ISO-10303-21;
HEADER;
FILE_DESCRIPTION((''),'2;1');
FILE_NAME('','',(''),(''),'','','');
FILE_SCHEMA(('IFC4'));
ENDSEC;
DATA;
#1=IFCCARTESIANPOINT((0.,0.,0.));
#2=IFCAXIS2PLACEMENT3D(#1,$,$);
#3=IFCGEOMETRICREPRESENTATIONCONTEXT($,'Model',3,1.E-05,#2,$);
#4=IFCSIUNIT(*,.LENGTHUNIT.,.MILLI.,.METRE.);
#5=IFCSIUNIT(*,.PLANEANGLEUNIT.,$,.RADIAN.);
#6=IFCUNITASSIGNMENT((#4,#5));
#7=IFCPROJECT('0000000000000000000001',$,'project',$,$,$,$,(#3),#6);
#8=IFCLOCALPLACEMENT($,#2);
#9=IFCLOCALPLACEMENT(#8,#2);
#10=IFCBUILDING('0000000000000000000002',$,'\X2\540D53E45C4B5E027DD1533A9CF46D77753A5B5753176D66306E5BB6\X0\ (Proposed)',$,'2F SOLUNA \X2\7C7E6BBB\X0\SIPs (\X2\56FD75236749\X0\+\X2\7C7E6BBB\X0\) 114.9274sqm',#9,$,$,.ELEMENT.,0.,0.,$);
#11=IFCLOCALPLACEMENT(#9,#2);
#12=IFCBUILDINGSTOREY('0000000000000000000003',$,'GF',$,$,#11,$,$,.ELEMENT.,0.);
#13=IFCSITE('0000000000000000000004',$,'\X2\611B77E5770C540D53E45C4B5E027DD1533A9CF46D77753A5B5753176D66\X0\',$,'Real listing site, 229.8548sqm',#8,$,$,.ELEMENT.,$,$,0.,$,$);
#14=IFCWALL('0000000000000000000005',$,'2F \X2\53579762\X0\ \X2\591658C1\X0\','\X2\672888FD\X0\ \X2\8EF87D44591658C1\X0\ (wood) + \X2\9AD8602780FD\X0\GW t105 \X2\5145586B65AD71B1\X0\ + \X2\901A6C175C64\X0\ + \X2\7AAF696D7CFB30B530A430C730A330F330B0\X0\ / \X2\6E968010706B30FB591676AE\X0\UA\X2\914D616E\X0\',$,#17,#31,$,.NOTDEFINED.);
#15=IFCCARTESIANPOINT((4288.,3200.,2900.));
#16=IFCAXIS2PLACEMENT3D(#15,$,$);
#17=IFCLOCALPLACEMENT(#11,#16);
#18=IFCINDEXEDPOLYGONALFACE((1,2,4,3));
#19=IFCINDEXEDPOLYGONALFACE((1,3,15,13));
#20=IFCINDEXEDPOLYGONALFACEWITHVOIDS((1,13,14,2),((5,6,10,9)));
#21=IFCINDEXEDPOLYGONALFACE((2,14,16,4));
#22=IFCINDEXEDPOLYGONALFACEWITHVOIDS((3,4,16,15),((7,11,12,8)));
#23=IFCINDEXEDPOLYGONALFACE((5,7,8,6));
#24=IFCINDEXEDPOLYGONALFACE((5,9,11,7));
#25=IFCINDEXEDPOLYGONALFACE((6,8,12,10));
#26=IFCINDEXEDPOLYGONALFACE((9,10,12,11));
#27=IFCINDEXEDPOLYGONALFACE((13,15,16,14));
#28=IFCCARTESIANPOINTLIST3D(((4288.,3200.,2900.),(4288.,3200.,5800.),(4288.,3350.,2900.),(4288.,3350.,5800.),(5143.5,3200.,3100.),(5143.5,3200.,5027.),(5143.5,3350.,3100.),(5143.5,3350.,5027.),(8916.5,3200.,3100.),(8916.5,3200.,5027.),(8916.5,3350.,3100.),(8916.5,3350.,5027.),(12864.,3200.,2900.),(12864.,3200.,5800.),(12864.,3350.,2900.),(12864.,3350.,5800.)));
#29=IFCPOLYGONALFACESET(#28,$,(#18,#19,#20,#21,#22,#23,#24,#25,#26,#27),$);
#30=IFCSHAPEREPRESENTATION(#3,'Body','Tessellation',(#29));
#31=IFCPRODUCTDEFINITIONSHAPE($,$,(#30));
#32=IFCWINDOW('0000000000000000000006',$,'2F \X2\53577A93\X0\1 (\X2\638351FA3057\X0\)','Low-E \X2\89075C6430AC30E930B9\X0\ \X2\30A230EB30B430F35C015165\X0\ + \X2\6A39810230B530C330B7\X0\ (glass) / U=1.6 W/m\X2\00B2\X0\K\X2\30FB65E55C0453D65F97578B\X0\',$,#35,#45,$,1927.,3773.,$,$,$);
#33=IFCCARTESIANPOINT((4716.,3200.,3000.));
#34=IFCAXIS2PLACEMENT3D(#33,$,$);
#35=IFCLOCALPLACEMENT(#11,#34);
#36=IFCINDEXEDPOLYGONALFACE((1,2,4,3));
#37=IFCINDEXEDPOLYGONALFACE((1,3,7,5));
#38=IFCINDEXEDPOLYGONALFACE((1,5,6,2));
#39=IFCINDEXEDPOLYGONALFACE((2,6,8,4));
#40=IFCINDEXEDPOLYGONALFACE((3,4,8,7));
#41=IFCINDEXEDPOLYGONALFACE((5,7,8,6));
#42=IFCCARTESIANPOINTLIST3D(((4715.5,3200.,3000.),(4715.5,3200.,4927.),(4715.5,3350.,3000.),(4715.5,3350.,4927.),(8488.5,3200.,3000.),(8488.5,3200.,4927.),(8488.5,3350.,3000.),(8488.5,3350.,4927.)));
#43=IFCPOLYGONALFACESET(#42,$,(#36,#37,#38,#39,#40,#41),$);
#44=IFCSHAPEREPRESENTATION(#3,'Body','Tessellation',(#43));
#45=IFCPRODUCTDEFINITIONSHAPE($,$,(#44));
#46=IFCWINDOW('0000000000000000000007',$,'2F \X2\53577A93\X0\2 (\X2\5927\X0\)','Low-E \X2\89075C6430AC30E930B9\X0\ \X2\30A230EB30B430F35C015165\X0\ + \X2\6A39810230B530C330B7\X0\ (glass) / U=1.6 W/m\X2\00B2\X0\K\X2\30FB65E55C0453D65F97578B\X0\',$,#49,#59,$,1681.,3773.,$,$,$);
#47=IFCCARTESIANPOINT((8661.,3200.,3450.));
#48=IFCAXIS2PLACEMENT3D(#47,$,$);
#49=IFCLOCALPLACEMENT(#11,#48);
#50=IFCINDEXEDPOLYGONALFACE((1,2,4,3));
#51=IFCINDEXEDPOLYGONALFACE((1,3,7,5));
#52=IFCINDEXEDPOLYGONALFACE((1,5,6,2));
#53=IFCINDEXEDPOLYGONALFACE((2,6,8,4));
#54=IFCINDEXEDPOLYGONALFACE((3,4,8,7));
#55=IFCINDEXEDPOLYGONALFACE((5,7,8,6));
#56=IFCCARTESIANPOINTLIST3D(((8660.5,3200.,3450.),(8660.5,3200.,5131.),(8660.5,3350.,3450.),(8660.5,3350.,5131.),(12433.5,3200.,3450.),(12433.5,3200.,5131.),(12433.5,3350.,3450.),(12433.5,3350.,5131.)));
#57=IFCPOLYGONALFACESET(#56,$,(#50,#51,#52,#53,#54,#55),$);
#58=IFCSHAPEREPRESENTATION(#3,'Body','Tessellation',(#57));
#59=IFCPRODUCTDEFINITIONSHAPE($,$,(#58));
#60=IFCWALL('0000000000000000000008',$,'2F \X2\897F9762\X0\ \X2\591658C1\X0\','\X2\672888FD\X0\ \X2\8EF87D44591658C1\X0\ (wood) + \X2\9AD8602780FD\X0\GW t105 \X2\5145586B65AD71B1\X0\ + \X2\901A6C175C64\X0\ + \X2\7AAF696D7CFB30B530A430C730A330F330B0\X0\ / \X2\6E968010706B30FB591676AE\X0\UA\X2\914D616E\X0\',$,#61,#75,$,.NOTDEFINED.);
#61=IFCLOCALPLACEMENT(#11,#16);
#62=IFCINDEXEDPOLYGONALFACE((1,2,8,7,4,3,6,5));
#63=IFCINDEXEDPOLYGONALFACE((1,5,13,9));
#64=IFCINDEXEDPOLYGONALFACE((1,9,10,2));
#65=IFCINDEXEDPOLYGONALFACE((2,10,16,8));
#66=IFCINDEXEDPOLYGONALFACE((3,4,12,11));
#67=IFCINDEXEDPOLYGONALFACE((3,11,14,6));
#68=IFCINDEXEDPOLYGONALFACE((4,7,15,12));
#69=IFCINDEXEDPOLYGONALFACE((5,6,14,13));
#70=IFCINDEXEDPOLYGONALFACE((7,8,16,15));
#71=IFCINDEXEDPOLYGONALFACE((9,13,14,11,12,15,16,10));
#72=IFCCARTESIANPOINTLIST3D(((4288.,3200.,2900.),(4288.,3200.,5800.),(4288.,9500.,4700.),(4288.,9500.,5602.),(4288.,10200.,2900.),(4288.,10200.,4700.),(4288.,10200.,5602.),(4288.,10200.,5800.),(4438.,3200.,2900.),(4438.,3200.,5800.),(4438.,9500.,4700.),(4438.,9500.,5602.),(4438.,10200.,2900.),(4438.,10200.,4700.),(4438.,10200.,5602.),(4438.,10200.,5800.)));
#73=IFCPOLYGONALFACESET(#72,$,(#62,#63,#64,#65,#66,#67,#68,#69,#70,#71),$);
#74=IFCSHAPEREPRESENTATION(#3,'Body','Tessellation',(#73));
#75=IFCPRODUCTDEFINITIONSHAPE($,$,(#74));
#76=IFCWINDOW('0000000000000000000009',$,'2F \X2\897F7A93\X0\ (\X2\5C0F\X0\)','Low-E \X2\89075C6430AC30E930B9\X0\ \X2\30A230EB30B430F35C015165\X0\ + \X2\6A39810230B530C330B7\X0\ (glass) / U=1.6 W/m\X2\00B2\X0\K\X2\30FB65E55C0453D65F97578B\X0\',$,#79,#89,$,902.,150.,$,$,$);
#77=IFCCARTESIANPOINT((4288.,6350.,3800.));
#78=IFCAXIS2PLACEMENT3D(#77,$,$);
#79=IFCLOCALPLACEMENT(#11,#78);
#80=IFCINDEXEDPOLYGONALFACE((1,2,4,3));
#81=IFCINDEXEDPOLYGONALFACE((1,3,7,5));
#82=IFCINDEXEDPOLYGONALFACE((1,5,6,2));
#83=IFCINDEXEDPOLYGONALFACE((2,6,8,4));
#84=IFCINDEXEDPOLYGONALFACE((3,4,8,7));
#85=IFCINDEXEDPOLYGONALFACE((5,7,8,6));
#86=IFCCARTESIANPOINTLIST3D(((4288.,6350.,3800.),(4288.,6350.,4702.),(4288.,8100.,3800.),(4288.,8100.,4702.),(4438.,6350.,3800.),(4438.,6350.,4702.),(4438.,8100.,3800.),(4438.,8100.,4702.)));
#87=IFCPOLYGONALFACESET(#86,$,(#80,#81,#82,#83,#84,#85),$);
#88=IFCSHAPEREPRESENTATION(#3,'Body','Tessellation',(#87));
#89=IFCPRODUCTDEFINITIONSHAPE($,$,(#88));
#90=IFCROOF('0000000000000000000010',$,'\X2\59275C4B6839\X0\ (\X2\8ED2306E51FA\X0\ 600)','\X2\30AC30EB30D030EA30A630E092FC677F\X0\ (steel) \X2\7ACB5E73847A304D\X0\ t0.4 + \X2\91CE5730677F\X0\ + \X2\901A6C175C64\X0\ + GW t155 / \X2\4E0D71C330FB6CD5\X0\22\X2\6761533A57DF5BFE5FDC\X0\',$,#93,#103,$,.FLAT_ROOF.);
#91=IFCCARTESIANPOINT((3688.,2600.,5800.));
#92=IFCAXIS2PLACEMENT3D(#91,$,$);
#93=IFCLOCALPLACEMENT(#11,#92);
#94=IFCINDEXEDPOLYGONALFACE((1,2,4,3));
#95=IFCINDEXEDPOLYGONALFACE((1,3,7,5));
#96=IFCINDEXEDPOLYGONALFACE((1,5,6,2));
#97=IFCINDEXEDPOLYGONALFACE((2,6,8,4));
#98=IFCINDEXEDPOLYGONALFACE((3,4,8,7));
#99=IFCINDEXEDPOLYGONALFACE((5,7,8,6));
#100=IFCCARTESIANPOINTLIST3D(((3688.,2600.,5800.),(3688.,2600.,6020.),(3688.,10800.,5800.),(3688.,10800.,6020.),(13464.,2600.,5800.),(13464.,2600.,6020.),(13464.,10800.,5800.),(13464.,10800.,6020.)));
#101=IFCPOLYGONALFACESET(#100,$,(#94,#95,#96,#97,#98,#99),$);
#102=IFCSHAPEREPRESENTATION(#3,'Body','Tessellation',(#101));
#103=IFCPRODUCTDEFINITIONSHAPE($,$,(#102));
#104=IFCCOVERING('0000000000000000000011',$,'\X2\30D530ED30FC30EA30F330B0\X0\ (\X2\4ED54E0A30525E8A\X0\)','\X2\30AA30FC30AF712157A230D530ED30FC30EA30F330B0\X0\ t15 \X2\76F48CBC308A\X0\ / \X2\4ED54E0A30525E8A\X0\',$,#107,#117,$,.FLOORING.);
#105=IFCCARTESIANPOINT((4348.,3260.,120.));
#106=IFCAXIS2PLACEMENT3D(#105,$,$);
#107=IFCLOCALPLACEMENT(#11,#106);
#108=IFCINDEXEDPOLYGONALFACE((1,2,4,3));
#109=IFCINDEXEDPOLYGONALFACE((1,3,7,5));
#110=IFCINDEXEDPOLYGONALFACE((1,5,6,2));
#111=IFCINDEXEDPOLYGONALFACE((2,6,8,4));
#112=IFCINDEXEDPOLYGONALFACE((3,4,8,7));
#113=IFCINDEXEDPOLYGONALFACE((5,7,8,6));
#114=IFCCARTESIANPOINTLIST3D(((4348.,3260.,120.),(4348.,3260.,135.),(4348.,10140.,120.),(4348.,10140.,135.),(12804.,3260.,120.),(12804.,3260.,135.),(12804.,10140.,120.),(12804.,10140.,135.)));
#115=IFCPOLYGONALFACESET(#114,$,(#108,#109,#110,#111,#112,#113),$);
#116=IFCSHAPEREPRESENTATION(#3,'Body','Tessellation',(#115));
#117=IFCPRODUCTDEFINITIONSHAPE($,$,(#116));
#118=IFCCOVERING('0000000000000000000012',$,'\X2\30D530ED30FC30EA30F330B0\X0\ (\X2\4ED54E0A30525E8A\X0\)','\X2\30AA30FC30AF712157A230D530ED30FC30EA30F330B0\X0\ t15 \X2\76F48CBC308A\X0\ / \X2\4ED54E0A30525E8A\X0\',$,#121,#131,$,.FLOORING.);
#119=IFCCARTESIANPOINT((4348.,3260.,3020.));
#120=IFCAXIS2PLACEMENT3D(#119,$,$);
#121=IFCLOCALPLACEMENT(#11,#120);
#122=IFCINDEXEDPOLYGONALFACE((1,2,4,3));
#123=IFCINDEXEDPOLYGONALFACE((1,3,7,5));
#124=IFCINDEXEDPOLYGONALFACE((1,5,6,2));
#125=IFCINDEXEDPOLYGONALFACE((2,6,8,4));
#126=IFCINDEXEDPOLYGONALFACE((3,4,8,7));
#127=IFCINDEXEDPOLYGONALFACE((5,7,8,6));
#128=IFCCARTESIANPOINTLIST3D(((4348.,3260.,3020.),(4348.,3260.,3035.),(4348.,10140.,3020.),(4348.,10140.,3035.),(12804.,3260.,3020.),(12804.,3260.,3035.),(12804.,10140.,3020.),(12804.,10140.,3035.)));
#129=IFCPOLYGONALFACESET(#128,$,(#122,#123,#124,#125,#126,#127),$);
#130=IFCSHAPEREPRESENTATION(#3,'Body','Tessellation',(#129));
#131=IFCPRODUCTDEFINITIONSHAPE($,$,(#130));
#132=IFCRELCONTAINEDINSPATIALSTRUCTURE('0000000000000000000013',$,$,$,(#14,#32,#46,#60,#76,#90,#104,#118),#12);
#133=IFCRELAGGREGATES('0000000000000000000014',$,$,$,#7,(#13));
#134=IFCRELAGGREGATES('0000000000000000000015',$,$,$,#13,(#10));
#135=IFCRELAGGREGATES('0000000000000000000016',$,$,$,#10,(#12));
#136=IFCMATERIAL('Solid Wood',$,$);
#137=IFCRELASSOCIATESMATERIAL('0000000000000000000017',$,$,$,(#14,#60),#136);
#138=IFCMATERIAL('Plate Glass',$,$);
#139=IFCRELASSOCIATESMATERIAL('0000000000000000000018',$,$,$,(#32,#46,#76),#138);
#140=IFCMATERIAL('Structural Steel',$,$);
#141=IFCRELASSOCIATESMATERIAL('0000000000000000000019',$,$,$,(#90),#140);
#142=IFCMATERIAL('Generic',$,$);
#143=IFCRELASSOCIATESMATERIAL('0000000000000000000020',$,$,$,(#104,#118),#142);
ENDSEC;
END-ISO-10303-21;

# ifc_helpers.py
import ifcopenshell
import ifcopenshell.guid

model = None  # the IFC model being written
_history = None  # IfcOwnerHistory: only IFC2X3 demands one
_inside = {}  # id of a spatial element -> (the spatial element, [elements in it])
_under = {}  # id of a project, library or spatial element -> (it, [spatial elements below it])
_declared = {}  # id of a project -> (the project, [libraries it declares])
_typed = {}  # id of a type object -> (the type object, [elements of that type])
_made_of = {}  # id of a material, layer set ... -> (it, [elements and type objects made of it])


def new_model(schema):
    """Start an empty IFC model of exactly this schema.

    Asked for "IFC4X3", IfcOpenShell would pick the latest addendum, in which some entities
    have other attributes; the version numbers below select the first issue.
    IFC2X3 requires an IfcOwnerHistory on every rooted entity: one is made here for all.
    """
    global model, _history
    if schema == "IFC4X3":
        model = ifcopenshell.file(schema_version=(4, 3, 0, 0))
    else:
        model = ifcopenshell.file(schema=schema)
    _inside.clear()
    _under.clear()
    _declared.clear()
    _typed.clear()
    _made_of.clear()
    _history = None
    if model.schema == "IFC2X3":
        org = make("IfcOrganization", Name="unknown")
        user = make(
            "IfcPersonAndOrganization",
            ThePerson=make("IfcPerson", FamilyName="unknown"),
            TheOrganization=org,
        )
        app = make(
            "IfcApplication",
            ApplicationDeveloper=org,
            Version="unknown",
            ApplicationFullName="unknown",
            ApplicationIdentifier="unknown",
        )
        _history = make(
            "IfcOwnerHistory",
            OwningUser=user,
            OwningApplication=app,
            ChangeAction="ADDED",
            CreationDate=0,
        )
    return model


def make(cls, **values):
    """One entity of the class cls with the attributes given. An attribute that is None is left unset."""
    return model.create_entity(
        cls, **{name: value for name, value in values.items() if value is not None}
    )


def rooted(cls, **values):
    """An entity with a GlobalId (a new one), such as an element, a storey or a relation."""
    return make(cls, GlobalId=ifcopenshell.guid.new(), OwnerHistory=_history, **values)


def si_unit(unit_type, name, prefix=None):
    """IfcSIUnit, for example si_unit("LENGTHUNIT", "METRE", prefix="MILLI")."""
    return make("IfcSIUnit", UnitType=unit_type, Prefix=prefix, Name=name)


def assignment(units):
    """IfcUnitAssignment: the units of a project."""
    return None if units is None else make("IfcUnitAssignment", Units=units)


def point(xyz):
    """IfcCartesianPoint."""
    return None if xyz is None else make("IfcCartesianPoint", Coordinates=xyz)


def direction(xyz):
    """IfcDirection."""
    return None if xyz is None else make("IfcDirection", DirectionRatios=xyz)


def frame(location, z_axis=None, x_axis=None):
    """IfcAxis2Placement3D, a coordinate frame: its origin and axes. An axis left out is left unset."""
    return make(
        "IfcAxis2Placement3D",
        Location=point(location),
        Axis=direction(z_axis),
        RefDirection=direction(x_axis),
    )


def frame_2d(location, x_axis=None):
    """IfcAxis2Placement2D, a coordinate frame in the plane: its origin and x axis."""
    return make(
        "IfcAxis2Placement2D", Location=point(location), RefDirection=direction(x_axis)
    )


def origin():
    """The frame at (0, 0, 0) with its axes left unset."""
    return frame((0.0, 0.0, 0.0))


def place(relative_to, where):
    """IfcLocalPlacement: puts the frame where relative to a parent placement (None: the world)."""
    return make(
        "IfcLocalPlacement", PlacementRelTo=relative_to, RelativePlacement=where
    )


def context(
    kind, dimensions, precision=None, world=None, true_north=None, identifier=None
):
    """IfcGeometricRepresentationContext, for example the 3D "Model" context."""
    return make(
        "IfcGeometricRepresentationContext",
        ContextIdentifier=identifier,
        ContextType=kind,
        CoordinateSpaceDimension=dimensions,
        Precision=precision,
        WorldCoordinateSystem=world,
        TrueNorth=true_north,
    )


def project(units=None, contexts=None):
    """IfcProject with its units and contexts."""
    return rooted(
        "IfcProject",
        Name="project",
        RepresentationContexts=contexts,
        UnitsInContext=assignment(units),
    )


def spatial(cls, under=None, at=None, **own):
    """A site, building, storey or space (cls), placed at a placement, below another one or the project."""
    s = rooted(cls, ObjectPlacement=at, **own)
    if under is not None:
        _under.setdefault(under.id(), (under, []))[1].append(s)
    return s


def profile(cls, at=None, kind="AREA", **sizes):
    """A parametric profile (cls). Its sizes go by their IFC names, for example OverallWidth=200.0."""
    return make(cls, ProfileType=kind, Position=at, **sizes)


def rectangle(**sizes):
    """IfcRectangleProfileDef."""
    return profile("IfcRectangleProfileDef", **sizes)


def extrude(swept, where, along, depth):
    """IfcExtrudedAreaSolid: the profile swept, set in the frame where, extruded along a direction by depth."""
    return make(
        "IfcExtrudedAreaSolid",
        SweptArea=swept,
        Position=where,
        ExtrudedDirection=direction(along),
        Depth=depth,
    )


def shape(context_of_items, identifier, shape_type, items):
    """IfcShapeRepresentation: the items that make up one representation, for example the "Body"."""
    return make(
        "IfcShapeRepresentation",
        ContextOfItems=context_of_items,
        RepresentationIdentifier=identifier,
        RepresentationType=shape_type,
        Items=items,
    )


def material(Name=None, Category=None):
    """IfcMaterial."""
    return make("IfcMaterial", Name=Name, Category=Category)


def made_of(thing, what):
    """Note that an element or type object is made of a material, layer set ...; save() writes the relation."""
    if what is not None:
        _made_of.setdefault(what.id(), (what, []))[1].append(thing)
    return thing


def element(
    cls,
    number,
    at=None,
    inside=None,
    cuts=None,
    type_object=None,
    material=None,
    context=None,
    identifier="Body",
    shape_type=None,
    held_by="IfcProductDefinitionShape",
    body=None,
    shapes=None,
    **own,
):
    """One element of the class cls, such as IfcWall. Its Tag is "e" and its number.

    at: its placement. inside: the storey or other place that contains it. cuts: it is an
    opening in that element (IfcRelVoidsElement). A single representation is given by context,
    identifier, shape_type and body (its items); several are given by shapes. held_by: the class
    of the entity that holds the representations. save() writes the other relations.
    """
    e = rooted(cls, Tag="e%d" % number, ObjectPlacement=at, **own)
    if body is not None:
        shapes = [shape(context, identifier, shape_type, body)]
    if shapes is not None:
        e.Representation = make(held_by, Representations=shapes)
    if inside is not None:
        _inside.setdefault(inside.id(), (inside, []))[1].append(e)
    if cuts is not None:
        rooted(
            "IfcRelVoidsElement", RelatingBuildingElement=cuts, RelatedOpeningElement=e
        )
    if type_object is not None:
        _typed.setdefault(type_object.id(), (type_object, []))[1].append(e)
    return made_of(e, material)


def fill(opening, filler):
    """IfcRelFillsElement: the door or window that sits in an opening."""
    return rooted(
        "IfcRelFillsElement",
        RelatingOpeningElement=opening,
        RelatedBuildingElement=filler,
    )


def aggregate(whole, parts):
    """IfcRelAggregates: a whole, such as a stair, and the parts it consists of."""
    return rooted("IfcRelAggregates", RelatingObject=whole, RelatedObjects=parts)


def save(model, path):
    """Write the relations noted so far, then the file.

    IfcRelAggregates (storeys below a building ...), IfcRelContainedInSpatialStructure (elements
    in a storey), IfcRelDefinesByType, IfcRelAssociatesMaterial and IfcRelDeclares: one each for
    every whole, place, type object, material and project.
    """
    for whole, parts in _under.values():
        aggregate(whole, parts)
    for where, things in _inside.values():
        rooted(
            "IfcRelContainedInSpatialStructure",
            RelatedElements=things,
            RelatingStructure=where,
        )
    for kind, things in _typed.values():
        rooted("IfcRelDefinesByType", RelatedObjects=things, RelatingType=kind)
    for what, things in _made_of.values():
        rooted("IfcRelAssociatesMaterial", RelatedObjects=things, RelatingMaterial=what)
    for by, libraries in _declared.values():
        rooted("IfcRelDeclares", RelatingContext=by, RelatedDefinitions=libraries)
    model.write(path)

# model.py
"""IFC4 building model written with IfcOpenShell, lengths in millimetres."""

from ifc_helpers import new_model, si_unit, frame, frame_2d, origin, place, context, project, spatial, rectangle, extrude, material, element, fill, save


model = new_model("IFC4")

# Units and contexts
model_context = context("Model", 3, precision=1e-05, world=origin())
ifc_project = project(units=[si_unit("LENGTHUNIT", "METRE", prefix="MILLI"), si_unit("PLANEANGLEUNIT", "RADIAN")], contexts=[model_context])

# Site, building, storey
site_placement = place(None, origin())
site = spatial("IfcSite", under=ifc_project, at=site_placement, Name="愛知県名古屋市緑区鳴海町字北浦", ObjectType="Real listing site, 229.8548sqm", CompositionType="ELEMENT", RefElevation=0.0)
building_placement = place(site_placement, origin())
building = spatial("IfcBuilding", under=site, at=building_placement, Name="名古屋市緑区鳴海町字北浦の家 (Proposed)", ObjectType="2F SOLUNA 籾殻SIPs (国産杉+籾殻) 114.9274sqm", CompositionType="ELEMENT", ElevationOfRefHeight=0.0, ElevationOfTerrain=0.0)
storey_placement = place(building_placement, origin())
storey = spatial("IfcBuildingStorey", under=building, at=storey_placement, Name="GF", CompositionType="ELEMENT", Elevation=0.0)

# Shared definitions
ifc_material_1 = material(Name="Solid Wood")

# Shared definitions
ifc_material_2 = material(Name="Plate Glass")

# Wall, openings, windows
wall_1_placement = place(storey_placement, frame((4288.0, 3200.0, 2900.0)))
wall_1 = element("IfcWall", 1, at=wall_1_placement, inside=storey, material=ifc_material_1, Name="2F 南面 外壁", Description="木製 軸組外壁 (wood) + 高性能GW t105 充填断熱 + 通気層 + 窯業系サイディング / 準耐火・外皮UA配慮", PredefinedType="NOTDEFINED", context=model_context, shape_type="SweptSolid", body=[
    extrude(rectangle(XDim=8576.0, YDim=150.0, at=frame_2d((4288.0, 75.0))), frame((4288.0, 3200.0, 2900.0)), (0.0, 0.0, 1.0), 2900.0),
])
opening_1_placement = place(storey_placement, frame((4716.0, 3200.0, 3000.0)))
opening_1 = element("IfcOpeningElement", 2, at=opening_1_placement, cuts=wall_1, PredefinedType="NOTDEFINED", context=model_context, shape_type="SweptSolid", body=[
    extrude(rectangle(XDim=3773.0, YDim=150.0, at=frame_2d((1886.0, 75.0))), frame((4716.0, 3200.0, 3000.0)), (0.0, 0.0, 1.0), 1927.0),
])
opening_2_placement = place(storey_placement, frame((8661.0, 3200.0, 3450.0)))
opening_2 = element("IfcOpeningElement", 3, at=opening_2_placement, cuts=wall_1, PredefinedType="NOTDEFINED", context=model_context, shape_type="SweptSolid", body=[
    extrude(rectangle(XDim=3773.0, YDim=150.0, at=frame_2d((1886.0, 75.0))), frame((8661.0, 3200.0, 3450.0)), (0.0, 0.0, 1.0), 1681.0),
])
window_1_placement = place(storey_placement, frame((4716.0, 3200.0, 3000.0)))
window_1 = element("IfcWindow", 4, at=window_1_placement, inside=storey, material=ifc_material_2, Name="2F 南窓1 (掃出し)", Description="Low-E 複層ガラス アルゴン封入 + 樹脂サッシ (glass) / U=1.6 W/m²K・日射取得型", OverallHeight=1927.0, OverallWidth=3773.0, context=model_context, shape_type="SweptSolid", body=[
    extrude(rectangle(XDim=3773.0, YDim=150.0, at=frame_2d((1886.0, 75.0))), frame((4716.0, 3200.0, 3000.0)), (0.0, 0.0, 1.0), 1927.0),
])
fill(opening_1, window_1)
window_2_placement = place(storey_placement, frame((8661.0, 3200.0, 3450.0)))
window_2 = element("IfcWindow", 5, at=window_2_placement, inside=storey, material=ifc_material_2, Name="2F 南窓2 (大)", Description="Low-E 複層ガラス アルゴン封入 + 樹脂サッシ (glass) / U=1.6 W/m²K・日射取得型", OverallHeight=1681.0, OverallWidth=3773.0, context=model_context, shape_type="SweptSolid", body=[
    extrude(rectangle(XDim=3773.0, YDim=150.0, at=frame_2d((1886.0, 75.0))), frame((8661.0, 3200.0, 3450.0)), (0.0, 0.0, 1.0), 1681.0),
])
fill(opening_2, window_2)

# Wall, opening, window
wall_2_placement = place(storey_placement, frame((4288.0, 3200.0, 2900.0)))
wall_2 = element("IfcWall", 6, at=wall_2_placement, inside=storey, material=ifc_material_1, Name="2F 西面 外壁", Description="木製 軸組外壁 (wood) + 高性能GW t105 充填断熱 + 通気層 + 窯業系サイディング / 準耐火・外皮UA配慮", PredefinedType="NOTDEFINED", context=model_context, shape_type="SweptSolid", body=[
    extrude(rectangle(XDim=150.0, YDim=7000.0, at=frame_2d((75.0, 3500.0))), frame((4288.0, 3200.0, 2900.0)), (0.0, 0.0, 1.0), 2900.0),
])
opening_3_placement = place(storey_placement, frame((4288.0, 6350.0, 3800.0)))
opening_3 = element("IfcOpeningElement", 7, at=opening_3_placement, cuts=wall_2, PredefinedType="NOTDEFINED", context=model_context, shape_type="SweptSolid", body=[
    extrude(rectangle(XDim=150.0, YDim=1750.0, at=frame_2d((75.0, 875.0))), frame((4288.0, 6350.0, 3800.0)), (0.0, 0.0, 1.0), 902.0),
])
window_3_placement = place(storey_placement, frame((4288.0, 6350.0, 3800.0)))
window_3 = element("IfcWindow", 8, at=window_3_placement, inside=storey, material=ifc_material_2, Name="2F 西窓 (小)", Description="Low-E 複層ガラス アルゴン封入 + 樹脂サッシ (glass) / U=1.6 W/m²K・日射取得型", OverallHeight=902.0, OverallWidth=150.0, context=model_context, shape_type="SweptSolid", body=[
    extrude(rectangle(XDim=150.0, YDim=1750.0, at=frame_2d((75.0, 875.0))), frame((4288.0, 6350.0, 3800.0)), (0.0, 0.0, 1.0), 902.0),
])
fill(opening_3, window_3)

# Roof
ifc_material_3 = material(Name="Structural Steel")
roof_placement = place(storey_placement, frame((3688.0, 2600.0, 5800.0)))
element("IfcRoof", 9, at=roof_placement, inside=storey, material=ifc_material_3, Name="大屋根 (軒の出 600)", Description="ガルバリウム鋼板 (steel) 立平葺き t0.4 + 野地板 + 通気層 + GW t155 / 不燃・法22条区域対応", PredefinedType="FLAT_ROOF", context=model_context, shape_type="SweptSolid", body=[
    extrude(rectangle(XDim=9776.0, YDim=8200.0, at=frame_2d((4888.0, 4100.0))), frame((3688.0, 2600.0, 5800.0)), (0.0, 0.0, 1.0), 220.0),
])

# Coverings
ifc_material_4 = material(Name="Generic")
covering_1_placement = place(storey_placement, frame((4348.0, 3260.0, 120.0)))
element("IfcCovering", 10, at=covering_1_placement, inside=storey, material=ifc_material_4, Name="フローリング (仕上げ床)", Description="オーク無垢フローリング t15 直貼り / 仕上げ床", PredefinedType="FLOORING", context=model_context, shape_type="SweptSolid", body=[
    extrude(rectangle(XDim=8456.0, YDim=6880.0, at=frame_2d((4228.0, 3440.0))), frame((4348.0, 3260.0, 120.0)), (0.0, 0.0, 1.0), 15.0),
])
covering_2_placement = place(storey_placement, frame((4348.0, 3260.0, 3020.0)))
element("IfcCovering", 11, at=covering_2_placement, inside=storey, material=ifc_material_4, Name="フローリング (仕上げ床)", Description="オーク無垢フローリング t15 直貼り / 仕上げ床", PredefinedType="FLOORING", context=model_context, shape_type="SweptSolid", body=[
    extrude(rectangle(XDim=8456.0, YDim=6880.0, at=frame_2d((4228.0, 3440.0))), frame((4348.0, 3260.0, 3020.0)), (0.0, 0.0, 1.0), 15.0),
])

save(model, "model.ifc")
